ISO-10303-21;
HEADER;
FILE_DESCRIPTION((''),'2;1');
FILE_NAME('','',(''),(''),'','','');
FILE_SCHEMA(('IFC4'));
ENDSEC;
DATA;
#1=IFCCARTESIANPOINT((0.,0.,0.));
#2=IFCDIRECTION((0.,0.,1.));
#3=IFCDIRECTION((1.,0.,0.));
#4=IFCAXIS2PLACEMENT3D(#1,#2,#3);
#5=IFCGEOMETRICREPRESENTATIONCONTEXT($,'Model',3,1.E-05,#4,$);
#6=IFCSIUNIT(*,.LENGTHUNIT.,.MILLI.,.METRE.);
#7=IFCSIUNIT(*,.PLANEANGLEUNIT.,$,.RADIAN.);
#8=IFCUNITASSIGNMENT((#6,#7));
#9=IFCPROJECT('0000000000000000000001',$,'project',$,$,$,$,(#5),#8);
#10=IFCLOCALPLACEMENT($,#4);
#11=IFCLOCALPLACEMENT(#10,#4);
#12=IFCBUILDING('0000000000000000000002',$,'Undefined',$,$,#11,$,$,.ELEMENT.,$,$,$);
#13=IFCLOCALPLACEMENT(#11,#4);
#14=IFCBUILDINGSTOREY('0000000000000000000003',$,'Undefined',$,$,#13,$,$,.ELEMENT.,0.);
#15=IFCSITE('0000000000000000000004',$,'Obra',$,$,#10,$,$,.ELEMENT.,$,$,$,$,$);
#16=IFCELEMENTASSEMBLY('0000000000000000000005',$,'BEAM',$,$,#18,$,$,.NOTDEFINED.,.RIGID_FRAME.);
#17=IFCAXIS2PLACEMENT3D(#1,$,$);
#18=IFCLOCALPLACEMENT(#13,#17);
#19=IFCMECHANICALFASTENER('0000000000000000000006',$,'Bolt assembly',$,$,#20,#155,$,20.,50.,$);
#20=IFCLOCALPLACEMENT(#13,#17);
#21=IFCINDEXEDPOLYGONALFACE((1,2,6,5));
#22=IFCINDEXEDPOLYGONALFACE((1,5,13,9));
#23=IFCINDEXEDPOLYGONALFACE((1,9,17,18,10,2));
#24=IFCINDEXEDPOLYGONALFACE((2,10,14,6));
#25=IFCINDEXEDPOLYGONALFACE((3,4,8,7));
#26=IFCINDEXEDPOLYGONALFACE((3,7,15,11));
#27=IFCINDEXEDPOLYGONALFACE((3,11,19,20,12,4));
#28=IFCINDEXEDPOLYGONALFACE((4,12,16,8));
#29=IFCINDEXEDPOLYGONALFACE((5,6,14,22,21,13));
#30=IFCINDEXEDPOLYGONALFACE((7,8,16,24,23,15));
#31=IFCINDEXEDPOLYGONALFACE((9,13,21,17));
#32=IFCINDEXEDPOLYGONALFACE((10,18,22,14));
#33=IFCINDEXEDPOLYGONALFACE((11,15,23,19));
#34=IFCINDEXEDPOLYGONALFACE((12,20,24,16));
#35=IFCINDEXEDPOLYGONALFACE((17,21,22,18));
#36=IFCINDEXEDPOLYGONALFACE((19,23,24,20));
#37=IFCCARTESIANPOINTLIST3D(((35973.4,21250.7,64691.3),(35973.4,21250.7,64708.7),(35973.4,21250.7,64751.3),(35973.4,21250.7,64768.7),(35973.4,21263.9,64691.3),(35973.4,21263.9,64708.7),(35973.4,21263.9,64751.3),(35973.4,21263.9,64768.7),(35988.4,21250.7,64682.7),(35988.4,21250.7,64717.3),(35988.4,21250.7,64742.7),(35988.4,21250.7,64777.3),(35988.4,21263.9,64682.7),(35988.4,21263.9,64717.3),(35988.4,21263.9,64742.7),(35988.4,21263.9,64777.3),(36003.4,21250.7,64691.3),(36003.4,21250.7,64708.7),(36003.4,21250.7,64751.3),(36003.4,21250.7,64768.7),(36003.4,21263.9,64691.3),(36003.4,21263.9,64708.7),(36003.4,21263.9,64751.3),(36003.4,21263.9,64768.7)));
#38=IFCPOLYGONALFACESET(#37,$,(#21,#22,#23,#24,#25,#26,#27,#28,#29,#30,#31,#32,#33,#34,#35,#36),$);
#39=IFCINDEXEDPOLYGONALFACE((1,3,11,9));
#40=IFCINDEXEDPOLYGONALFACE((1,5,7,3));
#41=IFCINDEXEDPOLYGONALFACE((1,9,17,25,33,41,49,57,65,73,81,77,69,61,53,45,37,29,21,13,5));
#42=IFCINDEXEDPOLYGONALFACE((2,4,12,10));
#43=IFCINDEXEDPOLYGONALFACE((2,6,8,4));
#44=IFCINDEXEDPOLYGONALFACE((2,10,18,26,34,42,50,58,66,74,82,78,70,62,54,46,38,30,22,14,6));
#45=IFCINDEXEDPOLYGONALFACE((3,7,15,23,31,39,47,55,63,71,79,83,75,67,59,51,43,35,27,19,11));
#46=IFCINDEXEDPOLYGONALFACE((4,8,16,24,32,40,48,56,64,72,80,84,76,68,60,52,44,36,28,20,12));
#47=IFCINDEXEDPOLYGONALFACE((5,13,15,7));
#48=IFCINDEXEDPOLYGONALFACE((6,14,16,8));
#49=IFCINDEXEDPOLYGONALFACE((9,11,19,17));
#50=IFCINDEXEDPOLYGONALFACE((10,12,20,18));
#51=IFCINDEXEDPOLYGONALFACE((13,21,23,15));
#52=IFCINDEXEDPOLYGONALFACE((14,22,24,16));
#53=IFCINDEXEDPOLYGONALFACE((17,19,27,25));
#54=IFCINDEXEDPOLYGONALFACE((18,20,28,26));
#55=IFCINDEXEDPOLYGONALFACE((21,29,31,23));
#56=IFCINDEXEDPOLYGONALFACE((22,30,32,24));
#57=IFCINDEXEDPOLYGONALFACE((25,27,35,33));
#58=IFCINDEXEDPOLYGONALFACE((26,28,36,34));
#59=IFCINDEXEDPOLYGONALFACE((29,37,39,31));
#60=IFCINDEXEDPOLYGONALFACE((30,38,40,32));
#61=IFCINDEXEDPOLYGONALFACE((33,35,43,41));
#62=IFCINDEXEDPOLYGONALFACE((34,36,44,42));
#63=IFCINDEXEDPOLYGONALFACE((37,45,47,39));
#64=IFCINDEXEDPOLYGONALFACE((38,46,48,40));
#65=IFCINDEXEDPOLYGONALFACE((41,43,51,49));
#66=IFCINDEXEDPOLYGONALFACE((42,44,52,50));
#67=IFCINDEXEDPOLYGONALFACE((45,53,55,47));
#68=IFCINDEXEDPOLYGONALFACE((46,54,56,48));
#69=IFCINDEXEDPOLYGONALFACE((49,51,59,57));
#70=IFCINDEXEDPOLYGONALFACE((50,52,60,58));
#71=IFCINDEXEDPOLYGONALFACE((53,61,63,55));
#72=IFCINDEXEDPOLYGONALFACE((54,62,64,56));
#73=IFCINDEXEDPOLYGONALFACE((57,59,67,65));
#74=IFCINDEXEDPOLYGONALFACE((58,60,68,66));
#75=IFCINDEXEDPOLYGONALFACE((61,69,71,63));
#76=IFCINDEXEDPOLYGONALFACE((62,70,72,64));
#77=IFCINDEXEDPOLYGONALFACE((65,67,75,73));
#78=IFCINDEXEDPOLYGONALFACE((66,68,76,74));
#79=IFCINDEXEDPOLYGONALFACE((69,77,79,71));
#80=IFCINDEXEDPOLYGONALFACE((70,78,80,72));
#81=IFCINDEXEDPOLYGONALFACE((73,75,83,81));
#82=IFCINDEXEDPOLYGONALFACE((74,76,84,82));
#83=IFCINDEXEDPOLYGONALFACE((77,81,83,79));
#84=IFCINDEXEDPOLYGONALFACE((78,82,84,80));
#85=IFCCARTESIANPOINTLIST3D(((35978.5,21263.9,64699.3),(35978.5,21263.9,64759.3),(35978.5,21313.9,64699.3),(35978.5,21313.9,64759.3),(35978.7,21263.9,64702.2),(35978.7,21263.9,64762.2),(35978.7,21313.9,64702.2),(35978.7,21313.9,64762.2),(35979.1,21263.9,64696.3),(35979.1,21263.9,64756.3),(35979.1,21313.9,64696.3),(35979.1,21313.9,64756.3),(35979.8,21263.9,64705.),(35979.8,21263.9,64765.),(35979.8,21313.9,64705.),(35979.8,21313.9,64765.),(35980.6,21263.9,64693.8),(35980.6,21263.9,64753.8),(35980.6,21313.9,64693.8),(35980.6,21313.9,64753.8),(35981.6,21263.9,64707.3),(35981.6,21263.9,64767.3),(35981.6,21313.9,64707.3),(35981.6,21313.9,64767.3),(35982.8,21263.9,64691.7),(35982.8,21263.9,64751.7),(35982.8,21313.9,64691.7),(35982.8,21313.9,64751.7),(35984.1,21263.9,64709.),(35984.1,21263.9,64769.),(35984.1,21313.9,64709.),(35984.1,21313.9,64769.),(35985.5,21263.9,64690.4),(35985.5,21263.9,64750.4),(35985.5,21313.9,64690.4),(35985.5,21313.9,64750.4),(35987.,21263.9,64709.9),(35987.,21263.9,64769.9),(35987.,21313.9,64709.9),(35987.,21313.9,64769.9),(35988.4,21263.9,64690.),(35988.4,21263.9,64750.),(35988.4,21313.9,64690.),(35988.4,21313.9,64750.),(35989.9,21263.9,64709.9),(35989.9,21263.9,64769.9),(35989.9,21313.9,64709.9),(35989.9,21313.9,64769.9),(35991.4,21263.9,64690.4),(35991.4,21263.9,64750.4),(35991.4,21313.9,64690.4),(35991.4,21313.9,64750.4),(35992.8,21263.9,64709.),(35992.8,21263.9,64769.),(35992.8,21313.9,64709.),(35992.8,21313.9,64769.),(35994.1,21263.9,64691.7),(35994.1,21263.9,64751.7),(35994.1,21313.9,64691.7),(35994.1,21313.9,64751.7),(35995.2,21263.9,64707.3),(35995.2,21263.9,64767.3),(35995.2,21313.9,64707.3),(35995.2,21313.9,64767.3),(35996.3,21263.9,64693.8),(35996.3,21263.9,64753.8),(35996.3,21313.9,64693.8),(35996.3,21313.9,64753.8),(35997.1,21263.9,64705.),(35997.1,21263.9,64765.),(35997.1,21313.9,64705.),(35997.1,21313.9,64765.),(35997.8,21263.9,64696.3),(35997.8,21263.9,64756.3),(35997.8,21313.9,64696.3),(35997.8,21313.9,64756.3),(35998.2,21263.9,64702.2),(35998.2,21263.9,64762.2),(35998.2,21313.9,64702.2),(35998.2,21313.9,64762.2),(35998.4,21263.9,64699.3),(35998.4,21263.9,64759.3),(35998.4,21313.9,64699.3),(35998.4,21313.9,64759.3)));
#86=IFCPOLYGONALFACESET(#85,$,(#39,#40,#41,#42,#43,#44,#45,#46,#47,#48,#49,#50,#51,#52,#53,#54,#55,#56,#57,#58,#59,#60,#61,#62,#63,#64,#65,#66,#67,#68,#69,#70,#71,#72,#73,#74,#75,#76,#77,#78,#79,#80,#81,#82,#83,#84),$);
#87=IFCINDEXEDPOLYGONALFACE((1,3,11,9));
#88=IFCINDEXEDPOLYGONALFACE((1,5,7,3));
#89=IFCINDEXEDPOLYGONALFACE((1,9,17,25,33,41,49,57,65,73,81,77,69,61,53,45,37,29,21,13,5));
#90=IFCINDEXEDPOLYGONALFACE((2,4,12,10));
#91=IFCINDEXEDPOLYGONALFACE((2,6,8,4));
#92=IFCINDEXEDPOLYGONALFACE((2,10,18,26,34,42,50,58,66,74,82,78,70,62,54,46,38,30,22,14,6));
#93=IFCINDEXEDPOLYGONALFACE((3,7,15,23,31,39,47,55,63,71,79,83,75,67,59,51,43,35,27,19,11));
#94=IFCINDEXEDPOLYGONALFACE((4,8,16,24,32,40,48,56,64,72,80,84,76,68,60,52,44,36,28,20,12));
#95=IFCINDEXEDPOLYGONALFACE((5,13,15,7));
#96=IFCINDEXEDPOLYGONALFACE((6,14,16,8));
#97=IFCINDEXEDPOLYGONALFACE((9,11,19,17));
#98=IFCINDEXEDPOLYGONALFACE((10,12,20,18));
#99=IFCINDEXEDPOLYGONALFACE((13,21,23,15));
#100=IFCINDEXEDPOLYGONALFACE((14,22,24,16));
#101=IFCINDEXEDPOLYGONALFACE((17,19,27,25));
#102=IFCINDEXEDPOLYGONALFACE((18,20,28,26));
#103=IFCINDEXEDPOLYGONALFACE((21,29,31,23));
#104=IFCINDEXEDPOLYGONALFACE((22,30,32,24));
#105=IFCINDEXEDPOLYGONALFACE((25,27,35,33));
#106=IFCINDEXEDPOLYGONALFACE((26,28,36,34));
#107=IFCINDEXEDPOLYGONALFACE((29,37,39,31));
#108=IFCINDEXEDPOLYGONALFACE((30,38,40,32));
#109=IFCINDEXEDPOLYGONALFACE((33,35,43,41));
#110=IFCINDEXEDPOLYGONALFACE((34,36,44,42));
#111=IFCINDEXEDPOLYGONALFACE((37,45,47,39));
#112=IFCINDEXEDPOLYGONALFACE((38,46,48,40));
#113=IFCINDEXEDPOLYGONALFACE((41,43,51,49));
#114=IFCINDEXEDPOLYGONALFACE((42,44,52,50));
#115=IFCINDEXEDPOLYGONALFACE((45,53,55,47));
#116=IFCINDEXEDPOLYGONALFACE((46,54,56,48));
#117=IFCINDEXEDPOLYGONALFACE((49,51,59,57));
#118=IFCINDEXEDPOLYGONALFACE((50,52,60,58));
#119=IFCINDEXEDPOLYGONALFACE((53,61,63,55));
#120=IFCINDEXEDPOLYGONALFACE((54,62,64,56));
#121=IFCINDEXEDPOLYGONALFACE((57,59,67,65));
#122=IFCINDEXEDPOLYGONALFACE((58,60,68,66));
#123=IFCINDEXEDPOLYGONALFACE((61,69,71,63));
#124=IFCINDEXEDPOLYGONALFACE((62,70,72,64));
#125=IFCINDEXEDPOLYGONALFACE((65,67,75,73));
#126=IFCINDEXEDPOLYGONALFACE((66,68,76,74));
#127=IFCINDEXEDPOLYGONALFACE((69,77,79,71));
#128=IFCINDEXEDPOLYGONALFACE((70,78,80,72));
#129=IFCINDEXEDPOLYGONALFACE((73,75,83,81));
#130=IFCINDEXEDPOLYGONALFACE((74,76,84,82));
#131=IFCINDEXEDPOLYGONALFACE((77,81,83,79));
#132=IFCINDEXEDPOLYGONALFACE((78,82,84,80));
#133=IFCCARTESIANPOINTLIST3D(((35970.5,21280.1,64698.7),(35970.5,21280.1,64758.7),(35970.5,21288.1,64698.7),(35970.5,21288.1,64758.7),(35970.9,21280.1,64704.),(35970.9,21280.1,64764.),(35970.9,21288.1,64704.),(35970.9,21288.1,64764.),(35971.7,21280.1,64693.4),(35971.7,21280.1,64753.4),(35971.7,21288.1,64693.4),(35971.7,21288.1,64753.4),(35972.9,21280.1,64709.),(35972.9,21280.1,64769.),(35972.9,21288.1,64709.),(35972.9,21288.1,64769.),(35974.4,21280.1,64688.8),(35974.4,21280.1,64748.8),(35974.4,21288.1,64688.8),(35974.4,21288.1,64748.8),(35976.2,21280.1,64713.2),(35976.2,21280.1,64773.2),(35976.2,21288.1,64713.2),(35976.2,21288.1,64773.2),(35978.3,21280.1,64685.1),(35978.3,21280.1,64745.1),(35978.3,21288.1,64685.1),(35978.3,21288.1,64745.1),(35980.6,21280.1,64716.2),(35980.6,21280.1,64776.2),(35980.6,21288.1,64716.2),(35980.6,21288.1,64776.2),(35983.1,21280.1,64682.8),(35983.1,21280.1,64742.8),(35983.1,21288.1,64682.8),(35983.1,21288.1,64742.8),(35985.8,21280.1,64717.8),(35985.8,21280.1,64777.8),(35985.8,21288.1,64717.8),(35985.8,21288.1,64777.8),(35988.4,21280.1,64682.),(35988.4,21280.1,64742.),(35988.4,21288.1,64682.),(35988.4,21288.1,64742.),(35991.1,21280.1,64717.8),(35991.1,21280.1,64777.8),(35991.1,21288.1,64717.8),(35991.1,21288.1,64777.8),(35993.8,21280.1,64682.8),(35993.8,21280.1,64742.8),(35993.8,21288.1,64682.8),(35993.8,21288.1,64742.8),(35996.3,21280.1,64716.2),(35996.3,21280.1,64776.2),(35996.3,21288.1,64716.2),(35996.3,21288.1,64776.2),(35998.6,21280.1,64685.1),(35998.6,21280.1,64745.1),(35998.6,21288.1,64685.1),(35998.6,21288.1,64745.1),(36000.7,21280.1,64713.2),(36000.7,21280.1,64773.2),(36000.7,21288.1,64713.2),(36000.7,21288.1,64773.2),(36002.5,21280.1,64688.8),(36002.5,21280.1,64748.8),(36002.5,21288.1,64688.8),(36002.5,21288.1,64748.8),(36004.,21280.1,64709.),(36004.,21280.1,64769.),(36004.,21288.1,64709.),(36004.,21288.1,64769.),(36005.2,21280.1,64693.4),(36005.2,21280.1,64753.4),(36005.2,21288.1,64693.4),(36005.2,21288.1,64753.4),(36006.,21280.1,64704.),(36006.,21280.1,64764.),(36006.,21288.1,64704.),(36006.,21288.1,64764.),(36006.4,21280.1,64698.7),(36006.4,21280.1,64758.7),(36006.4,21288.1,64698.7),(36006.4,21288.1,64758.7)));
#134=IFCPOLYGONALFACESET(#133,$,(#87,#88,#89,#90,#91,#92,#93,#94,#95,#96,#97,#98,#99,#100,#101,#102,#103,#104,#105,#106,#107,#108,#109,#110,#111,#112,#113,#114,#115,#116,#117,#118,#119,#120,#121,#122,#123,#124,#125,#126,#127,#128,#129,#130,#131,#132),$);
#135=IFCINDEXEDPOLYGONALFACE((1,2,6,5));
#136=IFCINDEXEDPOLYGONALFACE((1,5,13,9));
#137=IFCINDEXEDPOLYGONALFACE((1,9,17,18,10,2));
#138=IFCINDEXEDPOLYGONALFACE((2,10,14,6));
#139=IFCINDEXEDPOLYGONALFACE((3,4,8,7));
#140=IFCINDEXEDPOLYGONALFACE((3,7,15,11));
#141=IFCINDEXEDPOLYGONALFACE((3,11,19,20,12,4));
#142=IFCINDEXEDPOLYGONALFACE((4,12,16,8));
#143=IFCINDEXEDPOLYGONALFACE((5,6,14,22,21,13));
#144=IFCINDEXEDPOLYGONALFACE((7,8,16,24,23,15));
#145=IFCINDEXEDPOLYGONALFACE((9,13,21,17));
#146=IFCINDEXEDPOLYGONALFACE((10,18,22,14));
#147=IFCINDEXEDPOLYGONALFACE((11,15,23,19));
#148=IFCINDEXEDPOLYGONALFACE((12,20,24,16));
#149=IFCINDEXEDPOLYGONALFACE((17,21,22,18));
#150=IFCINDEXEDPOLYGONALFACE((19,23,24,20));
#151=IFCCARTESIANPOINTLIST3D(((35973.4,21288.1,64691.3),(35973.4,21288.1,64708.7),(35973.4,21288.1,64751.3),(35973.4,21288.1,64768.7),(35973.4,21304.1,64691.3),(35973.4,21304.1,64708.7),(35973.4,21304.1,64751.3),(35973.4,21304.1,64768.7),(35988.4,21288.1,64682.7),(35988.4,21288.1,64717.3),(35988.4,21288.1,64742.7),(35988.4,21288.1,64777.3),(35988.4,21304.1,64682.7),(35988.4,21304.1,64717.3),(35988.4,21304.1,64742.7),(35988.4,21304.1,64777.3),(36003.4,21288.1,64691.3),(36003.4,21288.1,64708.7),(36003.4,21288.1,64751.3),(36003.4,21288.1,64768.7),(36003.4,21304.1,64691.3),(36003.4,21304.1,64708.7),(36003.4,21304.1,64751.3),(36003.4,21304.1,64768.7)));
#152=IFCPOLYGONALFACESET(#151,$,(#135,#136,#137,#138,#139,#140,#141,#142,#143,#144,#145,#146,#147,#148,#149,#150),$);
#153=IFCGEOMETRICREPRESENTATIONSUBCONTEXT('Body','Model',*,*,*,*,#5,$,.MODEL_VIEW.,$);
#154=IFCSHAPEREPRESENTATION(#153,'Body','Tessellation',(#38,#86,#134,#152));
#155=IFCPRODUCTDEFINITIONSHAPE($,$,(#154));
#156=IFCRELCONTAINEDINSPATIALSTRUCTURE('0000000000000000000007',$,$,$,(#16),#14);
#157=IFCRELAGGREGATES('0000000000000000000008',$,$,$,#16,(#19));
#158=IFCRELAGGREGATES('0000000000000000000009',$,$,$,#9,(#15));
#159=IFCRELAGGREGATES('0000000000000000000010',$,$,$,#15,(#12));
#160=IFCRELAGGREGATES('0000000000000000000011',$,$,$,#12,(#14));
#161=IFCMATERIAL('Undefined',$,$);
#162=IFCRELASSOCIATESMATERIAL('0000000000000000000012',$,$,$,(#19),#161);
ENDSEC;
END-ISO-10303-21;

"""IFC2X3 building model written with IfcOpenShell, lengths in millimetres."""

from ifc_helpers import new_model, si_unit, frame, origin_with_axes, origin_2d_with_axis, place, context, subcontext, project, spatial, polyline, circle, outline, extrude, source, transform, mapped, material, element, aggregate, save


model = new_model("IFC2X3")

# Units and contexts
model_context = context("Model", 3, precision=1e-05, world=origin_with_axes())
body_context = subcontext(model_context, "Body", "Model", "MODEL_VIEW")
ifc_project = project(units=[si_unit("LENGTHUNIT", "METRE", prefix="MILLI"), si_unit("PLANEANGLEUNIT", "RADIAN")], contexts=[model_context])

# Site, building, storey
site_placement = place(None, origin_with_axes())
site = spatial("IfcSite", under=ifc_project, at=site_placement, Name="Obra", CompositionType="ELEMENT")
building_placement = place(site_placement, origin_with_axes())
building = spatial("IfcBuilding", under=site, at=building_placement, Name="Undefined", CompositionType="ELEMENT")
storey_placement = place(building_placement, origin_with_axes())
storey = spatial("IfcBuildingStorey", under=building, at=storey_placement, Name="Undefined", CompositionType="ELEMENT", Elevation=0.0)

# Shared definitions
ifc_material = material(Name="Undefined")

# Element assembly, mechanical fastener
shared_shape_1 = source(origin_with_axes(), body_context, "Body", "SweptSolid", [
    extrude(outline(polyline([(17.3, 0.0), (8.7, 15.0), (-8.7, 15.0), (-17.3, 0.0), (-8.7, -15.0), (8.7, -15.0), (17.3, 0.0)])), frame((0.0, -26.3, 0.0), z_axis=(0.0, 1.0, 0.0), x_axis=(1.0, 0.0, 0.0)), (0.0, 0.0, 1.0), 13.2),
    extrude(circle(Radius=10.0, at=origin_2d_with_axis()), frame((0.0, -13.1, 0.0), z_axis=(0.0, 1.0, 0.0), x_axis=(1.0, 0.0, 0.0)), (0.0, 0.0, 1.0), 50.0),
    extrude(circle(Radius=18.0, at=origin_2d_with_axis()), frame((0.0, 3.1, 0.0), z_axis=(0.0, 1.0, 0.0), x_axis=(1.0, 0.0, 0.0)), (0.0, 0.0, 1.0), 8.0),
    extrude(outline(polyline([(17.3, 0.0), (8.7, 15.0), (-8.7, 15.0), (-17.3, 0.0), (-8.7, -15.0), (8.7, -15.0), (17.3, 0.0)])), frame((0.0, 11.1, 0.0), z_axis=(0.0, 1.0, 0.0), x_axis=(1.0, 0.0, 0.0)), (0.0, 0.0, 1.0), 16.0),
])
assembly_1_placement = place(storey_placement, origin_with_axes())
assembly_1 = element("IfcElementAssembly", 1, at=assembly_1_placement, inside=storey, Name="BEAM", AssemblyPlace="NOTDEFINED", PredefinedType="RIGID_FRAME")
mechanical_fastener_1_placement = place(assembly_1_placement, frame((35948.4, 21277.0, 64850.0), z_axis=(1.0, 0.0, 0.0), x_axis=(0.0, 0.0, -1.0)))
mechanical_fastener_1 = element("IfcMechanicalFastener", 2, at=mechanical_fastener_1_placement, material=ifc_material, Name="Bolt assembly", NominalDiameter=20.0, NominalLength=50.0, context=body_context, shape_type="MappedRepresentation", body=[
    mapped(shared_shape_1, transform((90.0, 0.0, 40.0))),
    mapped(shared_shape_1, transform((150.0, 0.0, 40.0))),
])
aggregate(assembly_1, [mechanical_fastener_1])

save(model, "model.ifc")
